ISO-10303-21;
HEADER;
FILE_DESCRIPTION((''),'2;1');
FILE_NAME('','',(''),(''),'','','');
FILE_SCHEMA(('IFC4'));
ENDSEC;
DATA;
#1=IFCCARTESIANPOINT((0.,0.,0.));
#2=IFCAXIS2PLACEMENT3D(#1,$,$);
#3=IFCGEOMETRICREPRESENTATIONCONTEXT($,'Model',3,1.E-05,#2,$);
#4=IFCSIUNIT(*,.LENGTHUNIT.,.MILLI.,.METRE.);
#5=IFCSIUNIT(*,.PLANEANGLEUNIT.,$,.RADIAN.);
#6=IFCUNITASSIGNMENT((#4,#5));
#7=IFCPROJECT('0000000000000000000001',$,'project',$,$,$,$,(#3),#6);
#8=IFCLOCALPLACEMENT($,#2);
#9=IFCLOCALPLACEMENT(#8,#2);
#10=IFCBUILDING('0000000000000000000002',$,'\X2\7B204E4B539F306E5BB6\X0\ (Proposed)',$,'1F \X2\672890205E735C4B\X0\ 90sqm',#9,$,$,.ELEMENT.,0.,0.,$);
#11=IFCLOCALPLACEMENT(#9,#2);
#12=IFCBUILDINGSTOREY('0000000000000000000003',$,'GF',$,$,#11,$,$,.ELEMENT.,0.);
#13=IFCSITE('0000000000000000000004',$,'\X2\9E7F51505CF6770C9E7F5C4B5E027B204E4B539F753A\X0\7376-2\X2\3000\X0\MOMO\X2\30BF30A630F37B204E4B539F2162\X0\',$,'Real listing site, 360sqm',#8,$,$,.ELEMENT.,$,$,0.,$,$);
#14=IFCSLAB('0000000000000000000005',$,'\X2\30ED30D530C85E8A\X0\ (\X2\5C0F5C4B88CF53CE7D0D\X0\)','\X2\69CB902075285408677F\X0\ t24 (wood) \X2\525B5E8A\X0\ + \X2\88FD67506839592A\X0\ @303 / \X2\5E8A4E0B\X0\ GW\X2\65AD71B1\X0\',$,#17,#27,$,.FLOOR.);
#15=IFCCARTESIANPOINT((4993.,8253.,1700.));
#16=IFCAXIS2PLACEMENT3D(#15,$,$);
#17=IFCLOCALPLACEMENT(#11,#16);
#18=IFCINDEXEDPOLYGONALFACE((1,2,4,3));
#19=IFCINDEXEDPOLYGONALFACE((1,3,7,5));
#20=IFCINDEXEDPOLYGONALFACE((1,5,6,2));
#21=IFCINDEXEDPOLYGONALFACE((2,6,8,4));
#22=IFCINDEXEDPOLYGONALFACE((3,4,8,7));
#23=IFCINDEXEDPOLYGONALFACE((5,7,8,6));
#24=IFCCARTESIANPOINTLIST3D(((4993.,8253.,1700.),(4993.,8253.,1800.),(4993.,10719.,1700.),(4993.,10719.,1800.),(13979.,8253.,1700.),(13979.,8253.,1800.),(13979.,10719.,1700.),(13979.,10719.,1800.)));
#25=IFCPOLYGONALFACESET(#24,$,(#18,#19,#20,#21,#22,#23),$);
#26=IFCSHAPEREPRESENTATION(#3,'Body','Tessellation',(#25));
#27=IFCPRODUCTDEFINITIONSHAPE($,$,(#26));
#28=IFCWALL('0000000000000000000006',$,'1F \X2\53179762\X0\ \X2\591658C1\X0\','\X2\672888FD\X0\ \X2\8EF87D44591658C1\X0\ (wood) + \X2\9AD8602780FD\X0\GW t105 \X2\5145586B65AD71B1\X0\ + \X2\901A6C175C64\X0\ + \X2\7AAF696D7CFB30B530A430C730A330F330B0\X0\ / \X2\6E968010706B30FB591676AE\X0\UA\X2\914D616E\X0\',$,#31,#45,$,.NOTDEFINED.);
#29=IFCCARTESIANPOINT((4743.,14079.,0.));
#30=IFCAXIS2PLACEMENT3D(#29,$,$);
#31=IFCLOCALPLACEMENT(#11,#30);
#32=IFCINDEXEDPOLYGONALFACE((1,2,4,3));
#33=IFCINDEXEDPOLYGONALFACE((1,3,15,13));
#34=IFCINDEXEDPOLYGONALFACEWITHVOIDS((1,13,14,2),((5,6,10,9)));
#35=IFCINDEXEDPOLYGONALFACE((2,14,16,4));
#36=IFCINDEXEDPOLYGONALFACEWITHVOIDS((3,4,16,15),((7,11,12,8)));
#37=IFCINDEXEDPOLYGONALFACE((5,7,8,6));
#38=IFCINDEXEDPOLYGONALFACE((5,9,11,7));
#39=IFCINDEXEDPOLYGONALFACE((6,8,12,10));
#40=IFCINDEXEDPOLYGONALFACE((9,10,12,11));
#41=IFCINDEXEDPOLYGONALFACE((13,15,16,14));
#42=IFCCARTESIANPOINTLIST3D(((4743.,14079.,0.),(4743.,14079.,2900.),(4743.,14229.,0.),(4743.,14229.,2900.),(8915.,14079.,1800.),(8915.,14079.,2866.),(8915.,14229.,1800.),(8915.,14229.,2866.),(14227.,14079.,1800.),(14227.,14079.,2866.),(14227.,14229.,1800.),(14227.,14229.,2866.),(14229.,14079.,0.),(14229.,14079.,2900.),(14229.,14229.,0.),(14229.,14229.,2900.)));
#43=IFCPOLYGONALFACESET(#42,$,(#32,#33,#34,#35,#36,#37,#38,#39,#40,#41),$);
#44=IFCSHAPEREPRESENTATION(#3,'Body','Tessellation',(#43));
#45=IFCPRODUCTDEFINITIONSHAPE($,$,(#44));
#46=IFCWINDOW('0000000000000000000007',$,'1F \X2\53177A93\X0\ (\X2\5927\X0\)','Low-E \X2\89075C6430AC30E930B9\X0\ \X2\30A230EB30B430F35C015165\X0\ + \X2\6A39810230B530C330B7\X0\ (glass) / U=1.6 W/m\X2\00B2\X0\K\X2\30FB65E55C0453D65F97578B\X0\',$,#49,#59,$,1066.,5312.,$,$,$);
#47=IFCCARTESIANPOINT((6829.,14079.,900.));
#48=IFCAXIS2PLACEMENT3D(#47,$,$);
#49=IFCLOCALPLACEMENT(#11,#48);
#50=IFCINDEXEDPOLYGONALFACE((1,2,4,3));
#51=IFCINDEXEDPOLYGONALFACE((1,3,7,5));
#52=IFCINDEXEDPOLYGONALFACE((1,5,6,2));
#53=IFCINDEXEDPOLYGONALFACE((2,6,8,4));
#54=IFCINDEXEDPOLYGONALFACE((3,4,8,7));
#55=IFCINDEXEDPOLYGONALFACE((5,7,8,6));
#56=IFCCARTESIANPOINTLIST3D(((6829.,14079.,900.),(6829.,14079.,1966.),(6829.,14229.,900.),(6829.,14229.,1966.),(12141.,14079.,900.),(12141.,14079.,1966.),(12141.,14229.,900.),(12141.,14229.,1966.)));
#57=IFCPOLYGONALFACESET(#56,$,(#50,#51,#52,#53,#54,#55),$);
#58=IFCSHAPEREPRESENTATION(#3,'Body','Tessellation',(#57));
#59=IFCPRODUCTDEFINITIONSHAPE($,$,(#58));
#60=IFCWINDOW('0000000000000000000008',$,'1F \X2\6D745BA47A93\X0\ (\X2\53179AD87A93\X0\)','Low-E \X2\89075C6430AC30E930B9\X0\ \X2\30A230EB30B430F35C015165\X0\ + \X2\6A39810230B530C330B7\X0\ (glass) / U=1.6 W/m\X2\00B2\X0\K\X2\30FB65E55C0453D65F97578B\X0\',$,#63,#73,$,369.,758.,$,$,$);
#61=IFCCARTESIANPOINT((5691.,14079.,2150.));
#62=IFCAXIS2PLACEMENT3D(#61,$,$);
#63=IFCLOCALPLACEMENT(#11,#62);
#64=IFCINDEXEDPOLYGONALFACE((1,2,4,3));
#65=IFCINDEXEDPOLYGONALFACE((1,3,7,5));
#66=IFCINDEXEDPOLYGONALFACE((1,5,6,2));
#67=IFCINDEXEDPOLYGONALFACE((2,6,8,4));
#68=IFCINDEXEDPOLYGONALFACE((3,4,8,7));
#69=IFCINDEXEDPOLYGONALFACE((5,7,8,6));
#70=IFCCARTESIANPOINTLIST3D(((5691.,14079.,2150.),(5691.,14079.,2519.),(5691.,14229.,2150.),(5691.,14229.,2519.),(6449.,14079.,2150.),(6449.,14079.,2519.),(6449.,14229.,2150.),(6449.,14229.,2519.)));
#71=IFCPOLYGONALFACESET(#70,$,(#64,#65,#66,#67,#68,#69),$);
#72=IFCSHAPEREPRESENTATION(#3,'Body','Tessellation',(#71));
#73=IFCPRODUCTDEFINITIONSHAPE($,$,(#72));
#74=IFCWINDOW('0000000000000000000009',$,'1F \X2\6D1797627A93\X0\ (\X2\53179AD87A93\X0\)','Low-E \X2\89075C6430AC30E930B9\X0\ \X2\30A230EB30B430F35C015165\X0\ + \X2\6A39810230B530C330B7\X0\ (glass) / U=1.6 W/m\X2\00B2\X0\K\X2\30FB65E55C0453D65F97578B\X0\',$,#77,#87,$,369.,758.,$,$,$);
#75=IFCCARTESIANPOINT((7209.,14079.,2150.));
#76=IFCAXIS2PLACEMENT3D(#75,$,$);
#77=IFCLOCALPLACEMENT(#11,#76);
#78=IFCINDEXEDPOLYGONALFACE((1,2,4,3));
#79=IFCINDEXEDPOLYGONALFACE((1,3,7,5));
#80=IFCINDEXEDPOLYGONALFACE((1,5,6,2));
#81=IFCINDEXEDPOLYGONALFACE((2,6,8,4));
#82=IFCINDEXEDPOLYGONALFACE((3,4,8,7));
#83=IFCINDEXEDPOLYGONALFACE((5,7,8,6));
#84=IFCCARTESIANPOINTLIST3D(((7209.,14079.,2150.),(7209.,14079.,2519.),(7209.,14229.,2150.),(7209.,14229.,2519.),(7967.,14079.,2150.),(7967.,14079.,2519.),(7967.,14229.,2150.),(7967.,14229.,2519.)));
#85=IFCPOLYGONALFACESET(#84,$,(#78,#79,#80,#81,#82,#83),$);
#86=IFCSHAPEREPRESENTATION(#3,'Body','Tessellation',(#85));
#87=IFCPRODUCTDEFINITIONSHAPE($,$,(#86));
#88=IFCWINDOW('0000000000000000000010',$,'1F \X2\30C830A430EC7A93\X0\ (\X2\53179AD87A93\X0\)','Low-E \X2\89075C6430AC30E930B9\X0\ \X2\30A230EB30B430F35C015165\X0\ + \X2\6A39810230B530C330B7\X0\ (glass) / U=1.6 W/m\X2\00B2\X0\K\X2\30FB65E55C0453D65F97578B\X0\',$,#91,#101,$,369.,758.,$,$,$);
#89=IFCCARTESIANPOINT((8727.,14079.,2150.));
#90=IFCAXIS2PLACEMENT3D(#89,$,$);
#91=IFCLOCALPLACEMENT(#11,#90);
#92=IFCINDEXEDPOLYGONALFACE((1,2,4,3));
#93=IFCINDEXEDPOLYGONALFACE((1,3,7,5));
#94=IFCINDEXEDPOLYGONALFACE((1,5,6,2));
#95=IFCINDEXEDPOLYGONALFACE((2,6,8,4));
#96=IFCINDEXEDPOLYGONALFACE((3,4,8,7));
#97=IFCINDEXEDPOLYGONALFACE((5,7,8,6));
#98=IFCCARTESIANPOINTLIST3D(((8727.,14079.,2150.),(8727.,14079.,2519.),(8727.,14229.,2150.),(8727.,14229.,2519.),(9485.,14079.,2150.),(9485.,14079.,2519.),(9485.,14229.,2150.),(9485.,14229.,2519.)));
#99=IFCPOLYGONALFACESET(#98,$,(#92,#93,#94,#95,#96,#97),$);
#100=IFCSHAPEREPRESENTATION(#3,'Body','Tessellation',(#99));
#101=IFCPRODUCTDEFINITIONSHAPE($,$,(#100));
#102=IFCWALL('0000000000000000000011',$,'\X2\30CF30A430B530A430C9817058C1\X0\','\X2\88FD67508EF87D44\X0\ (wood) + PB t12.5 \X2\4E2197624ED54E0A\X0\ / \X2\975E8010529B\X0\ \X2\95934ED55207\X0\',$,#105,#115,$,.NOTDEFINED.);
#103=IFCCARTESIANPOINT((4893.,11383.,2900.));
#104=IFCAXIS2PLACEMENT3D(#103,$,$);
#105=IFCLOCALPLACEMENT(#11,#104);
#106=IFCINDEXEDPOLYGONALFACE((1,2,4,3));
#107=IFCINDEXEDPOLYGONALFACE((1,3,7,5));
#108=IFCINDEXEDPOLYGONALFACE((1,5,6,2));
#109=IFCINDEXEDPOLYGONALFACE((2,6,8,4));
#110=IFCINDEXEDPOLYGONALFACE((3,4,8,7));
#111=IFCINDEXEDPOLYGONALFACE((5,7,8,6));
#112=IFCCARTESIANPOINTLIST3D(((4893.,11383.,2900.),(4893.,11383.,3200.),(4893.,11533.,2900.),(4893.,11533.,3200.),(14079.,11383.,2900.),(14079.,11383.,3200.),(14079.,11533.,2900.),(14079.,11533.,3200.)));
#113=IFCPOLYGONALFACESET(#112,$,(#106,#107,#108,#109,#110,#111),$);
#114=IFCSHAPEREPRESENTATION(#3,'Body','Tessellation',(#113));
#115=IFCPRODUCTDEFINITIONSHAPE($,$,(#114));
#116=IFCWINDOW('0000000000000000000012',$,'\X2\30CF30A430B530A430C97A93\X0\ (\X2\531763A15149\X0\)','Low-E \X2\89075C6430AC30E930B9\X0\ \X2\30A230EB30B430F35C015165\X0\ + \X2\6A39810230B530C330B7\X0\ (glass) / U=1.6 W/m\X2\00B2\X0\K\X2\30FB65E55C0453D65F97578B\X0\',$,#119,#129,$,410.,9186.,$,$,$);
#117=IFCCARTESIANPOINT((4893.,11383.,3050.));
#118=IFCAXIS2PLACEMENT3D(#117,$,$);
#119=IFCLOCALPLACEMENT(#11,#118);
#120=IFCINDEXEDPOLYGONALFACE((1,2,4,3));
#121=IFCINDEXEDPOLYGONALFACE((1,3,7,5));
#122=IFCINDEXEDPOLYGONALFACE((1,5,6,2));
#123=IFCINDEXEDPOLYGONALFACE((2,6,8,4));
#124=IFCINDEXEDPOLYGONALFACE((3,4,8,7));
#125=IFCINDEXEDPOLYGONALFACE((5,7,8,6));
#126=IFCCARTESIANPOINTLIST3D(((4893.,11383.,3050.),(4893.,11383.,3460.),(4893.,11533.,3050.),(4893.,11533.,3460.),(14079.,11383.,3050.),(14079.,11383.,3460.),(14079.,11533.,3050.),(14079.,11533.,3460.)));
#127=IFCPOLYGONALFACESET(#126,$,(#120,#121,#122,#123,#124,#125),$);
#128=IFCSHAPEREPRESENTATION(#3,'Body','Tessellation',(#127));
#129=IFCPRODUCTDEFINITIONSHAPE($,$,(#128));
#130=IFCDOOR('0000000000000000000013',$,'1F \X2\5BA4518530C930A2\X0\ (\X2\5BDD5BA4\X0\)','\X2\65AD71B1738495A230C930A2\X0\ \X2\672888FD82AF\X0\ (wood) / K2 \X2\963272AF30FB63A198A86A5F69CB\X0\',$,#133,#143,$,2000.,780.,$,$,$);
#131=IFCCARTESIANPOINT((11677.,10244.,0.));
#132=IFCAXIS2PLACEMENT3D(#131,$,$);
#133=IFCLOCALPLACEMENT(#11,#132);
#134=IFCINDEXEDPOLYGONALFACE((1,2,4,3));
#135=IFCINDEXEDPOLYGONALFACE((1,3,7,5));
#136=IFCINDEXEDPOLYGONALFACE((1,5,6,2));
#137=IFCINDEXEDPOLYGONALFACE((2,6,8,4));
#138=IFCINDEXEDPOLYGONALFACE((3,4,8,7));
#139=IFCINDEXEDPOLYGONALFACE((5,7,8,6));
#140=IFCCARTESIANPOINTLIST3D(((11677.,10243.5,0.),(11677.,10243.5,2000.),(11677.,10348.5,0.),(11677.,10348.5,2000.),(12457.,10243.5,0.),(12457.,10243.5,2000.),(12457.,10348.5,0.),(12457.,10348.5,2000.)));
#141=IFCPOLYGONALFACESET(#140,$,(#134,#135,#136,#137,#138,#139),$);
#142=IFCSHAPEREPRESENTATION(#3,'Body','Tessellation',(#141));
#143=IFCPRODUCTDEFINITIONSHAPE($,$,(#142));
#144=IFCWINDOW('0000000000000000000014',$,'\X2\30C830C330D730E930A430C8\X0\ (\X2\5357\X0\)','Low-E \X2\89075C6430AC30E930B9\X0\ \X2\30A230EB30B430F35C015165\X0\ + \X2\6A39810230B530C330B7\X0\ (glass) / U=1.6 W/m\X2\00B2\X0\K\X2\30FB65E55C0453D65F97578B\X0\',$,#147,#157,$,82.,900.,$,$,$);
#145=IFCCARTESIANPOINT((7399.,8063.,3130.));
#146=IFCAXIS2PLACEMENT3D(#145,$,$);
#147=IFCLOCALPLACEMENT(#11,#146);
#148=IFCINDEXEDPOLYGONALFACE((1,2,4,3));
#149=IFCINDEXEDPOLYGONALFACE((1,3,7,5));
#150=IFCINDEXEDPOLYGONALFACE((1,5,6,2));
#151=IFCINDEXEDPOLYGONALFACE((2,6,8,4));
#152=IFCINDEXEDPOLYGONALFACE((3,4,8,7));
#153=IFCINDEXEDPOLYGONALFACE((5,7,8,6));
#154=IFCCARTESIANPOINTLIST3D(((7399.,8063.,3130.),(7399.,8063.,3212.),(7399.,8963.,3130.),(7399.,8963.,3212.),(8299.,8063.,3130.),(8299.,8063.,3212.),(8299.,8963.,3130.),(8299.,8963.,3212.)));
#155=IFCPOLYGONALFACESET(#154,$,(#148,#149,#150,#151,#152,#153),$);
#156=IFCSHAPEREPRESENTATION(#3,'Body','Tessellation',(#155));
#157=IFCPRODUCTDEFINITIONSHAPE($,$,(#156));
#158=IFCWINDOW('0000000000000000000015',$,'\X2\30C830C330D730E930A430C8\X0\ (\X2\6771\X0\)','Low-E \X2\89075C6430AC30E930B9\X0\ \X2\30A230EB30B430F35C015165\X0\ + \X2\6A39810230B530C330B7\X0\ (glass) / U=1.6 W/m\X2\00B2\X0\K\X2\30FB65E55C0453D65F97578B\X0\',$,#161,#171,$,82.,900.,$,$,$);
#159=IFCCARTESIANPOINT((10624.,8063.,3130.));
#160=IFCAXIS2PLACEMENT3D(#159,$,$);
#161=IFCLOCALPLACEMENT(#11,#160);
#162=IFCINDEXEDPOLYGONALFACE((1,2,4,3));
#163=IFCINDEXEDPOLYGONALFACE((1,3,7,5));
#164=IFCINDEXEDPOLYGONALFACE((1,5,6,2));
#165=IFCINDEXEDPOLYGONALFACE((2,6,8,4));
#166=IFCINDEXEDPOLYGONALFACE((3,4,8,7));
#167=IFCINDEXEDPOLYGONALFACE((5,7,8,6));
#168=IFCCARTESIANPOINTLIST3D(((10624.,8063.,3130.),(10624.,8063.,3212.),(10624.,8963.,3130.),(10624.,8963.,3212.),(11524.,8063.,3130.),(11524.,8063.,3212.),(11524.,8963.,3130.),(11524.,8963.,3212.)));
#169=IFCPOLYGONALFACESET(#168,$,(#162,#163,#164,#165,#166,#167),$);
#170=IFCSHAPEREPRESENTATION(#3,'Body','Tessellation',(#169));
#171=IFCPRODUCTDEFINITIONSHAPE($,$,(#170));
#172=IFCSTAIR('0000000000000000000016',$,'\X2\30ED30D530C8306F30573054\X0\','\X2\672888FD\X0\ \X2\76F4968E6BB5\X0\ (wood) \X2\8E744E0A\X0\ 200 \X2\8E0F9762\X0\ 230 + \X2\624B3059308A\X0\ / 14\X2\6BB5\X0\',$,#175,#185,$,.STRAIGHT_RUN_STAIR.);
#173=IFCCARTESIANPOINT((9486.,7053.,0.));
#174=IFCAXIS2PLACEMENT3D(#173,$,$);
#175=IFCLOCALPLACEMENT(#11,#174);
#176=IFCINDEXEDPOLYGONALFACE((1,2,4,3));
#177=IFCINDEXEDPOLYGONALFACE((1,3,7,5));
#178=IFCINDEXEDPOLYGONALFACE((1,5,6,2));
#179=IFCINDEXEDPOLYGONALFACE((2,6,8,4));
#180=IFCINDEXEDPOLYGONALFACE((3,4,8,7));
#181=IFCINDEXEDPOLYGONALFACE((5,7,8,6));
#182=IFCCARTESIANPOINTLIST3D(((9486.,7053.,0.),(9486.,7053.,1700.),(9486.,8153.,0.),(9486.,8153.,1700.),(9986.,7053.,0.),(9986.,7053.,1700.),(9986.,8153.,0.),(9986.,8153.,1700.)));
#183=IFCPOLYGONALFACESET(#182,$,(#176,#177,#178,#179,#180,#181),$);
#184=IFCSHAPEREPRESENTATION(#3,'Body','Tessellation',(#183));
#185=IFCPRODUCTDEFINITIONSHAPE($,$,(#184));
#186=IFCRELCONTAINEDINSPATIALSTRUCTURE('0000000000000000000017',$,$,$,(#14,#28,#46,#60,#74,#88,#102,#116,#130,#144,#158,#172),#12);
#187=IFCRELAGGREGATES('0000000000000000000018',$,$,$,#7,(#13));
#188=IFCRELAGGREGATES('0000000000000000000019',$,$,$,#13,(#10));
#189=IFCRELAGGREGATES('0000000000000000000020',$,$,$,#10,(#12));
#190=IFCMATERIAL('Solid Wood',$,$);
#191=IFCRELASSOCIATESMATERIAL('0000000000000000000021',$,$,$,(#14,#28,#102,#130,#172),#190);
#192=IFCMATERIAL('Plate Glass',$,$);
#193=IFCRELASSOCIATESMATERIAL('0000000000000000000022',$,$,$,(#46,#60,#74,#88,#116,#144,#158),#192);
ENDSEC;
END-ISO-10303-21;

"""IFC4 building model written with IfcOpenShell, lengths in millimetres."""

from ifc_helpers import new_model, si_unit, frame, frame_2d, origin, place, context, project, spatial, rectangle, extrude, material, element, fill, save


model = new_model("IFC4")

# Units and contexts
model_context = context("Model", 3, precision=1e-05, world=origin())
ifc_project = project(units=[si_unit("LENGTHUNIT", "METRE", prefix="MILLI"), si_unit("PLANEANGLEUNIT", "RADIAN")], contexts=[model_context])

# Site, building, storey
site_placement = place(None, origin())
site = spatial("IfcSite", under=ifc_project, at=site_placement, Name="鹿児島県鹿屋市笠之原町7376-2　MOMOタウン笠之原Ⅲ", ObjectType="Real listing site, 360sqm", CompositionType="ELEMENT", RefElevation=0.0)
building_placement = place(site_placement, origin())
building = spatial("IfcBuilding", under=site, at=building_placement, Name="笠之原の家 (Proposed)", ObjectType="1F 木造平屋 90sqm", CompositionType="ELEMENT", ElevationOfRefHeight=0.0, ElevationOfTerrain=0.0)
storey_placement = place(building_placement, origin())
storey = spatial("IfcBuildingStorey", under=building, at=storey_placement, Name="GF", CompositionType="ELEMENT", Elevation=0.0)

# Slab
ifc_material_1 = material(Name="Solid Wood")
slab_placement = place(storey_placement, frame((4993.0, 8253.0, 1700.0)))
element("IfcSlab", 1, at=slab_placement, inside=storey, material=ifc_material_1, Name="ロフト床 (小屋裏収納)", Description="構造用合板 t24 (wood) 剛床 + 製材根太 @303 / 床下 GW断熱", PredefinedType="FLOOR", context=model_context, shape_type="SweptSolid", body=[
    extrude(rectangle(XDim=8986.0, YDim=2466.0, at=frame_2d((4493.0, 1233.0))), frame((4993.0, 8253.0, 1700.0)), (0.0, 0.0, 1.0), 100.0),
])

# Wall, openings, windows
wall_1_placement = place(storey_placement, frame((4743.0, 14079.0, 0.0)))
wall_1 = element("IfcWall", 2, at=wall_1_placement, inside=storey, material=ifc_material_1, Name="1F 北面 外壁", Description="木製 軸組外壁 (wood) + 高性能GW t105 充填断熱 + 通気層 + 窯業系サイディング / 準耐火・外皮UA配慮", PredefinedType="NOTDEFINED", context=model_context, shape_type="SweptSolid", body=[
    extrude(rectangle(XDim=9486.0, YDim=150.0, at=frame_2d((4743.0, 75.0))), frame((4743.0, 14079.0, 0.0)), (0.0, 0.0, 1.0), 2900.0),
])
opening_1_placement = place(storey_placement, frame((6829.0, 14079.0, 900.0)))
opening_1 = element("IfcOpeningElement", 3, at=opening_1_placement, cuts=wall_1, PredefinedType="NOTDEFINED", context=model_context, shape_type="SweptSolid", body=[
    extrude(rectangle(XDim=5312.0, YDim=150.0, at=frame_2d((2656.0, 75.0))), frame((6829.0, 14079.0, 900.0)), (0.0, 0.0, 1.0), 1066.0),
])
opening_2_placement = place(storey_placement, frame((5691.0, 14079.0, 2150.0)))
opening_2 = element("IfcOpeningElement", 4, at=opening_2_placement, cuts=wall_1, PredefinedType="NOTDEFINED", context=model_context, shape_type="SweptSolid", body=[
    extrude(rectangle(XDim=758.0, YDim=150.0, at=frame_2d((379.0, 75.0))), frame((5691.0, 14079.0, 2150.0)), (0.0, 0.0, 1.0), 369.0),
])
opening_3_placement = place(storey_placement, frame((7209.0, 14079.0, 2150.0)))
opening_3 = element("IfcOpeningElement", 5, at=opening_3_placement, cuts=wall_1, PredefinedType="NOTDEFINED", context=model_context, shape_type="SweptSolid", body=[
    extrude(rectangle(XDim=758.0, YDim=150.0, at=frame_2d((379.0, 75.0))), frame((7209.0, 14079.0, 2150.0)), (0.0, 0.0, 1.0), 369.0),
])
opening_4_placement = place(storey_placement, frame((8727.0, 14079.0, 2150.0)))
opening_4 = element("IfcOpeningElement", 6, at=opening_4_placement, cuts=wall_1, PredefinedType="NOTDEFINED", context=model_context, shape_type="SweptSolid", body=[
    extrude(rectangle(XDim=758.0, YDim=150.0, at=frame_2d((379.0, 75.0))), frame((8727.0, 14079.0, 2150.0)), (0.0, 0.0, 1.0), 369.0),
])
ifc_material_2 = material(Name="Plate Glass")
window_1_placement = place(storey_placement, frame((6829.0, 14079.0, 900.0)))
window_1 = element("IfcWindow", 7, at=window_1_placement, inside=storey, material=ifc_material_2, Name="1F 北窓 (大)", Description="Low-E 複層ガラス アルゴン封入 + 樹脂サッシ (glass) / U=1.6 W/m²K・日射取得型", OverallHeight=1066.0, OverallWidth=5312.0, context=model_context, shape_type="SweptSolid", body=[
    extrude(rectangle(XDim=5312.0, YDim=150.0, at=frame_2d((2656.0, 75.0))), frame((6829.0, 14079.0, 900.0)), (0.0, 0.0, 1.0), 1066.0),
])
fill(opening_1, window_1)
window_2_placement = place(storey_placement, frame((5691.0, 14079.0, 2150.0)))
window_2 = element("IfcWindow", 8, at=window_2_placement, inside=storey, material=ifc_material_2, Name="1F 浴室窓 (北高窓)", Description="Low-E 複層ガラス アルゴン封入 + 樹脂サッシ (glass) / U=1.6 W/m²K・日射取得型", OverallHeight=369.0, OverallWidth=758.0, context=model_context, shape_type="SweptSolid", body=[
    extrude(rectangle(XDim=758.0, YDim=150.0, at=frame_2d((379.0, 75.0))), frame((5691.0, 14079.0, 2150.0)), (0.0, 0.0, 1.0), 369.0),
])
fill(opening_2, window_2)
window_3_placement = place(storey_placement, frame((7209.0, 14079.0, 2150.0)))
window_3 = element("IfcWindow", 9, at=window_3_placement, inside=storey, material=ifc_material_2, Name="1F 洗面窓 (北高窓)", Description="Low-E 複層ガラス アルゴン封入 + 樹脂サッシ (glass) / U=1.6 W/m²K・日射取得型", OverallHeight=369.0, OverallWidth=758.0, context=model_context, shape_type="SweptSolid", body=[
    extrude(rectangle(XDim=758.0, YDim=150.0, at=frame_2d((379.0, 75.0))), frame((7209.0, 14079.0, 2150.0)), (0.0, 0.0, 1.0), 369.0),
])
fill(opening_3, window_3)
window_4_placement = place(storey_placement, frame((8727.0, 14079.0, 2150.0)))
window_4 = element("IfcWindow", 10, at=window_4_placement, inside=storey, material=ifc_material_2, Name="1F トイレ窓 (北高窓)", Description="Low-E 複層ガラス アルゴン封入 + 樹脂サッシ (glass) / U=1.6 W/m²K・日射取得型", OverallHeight=369.0, OverallWidth=758.0, context=model_context, shape_type="SweptSolid", body=[
    extrude(rectangle(XDim=758.0, YDim=150.0, at=frame_2d((379.0, 75.0))), frame((8727.0, 14079.0, 2150.0)), (0.0, 0.0, 1.0), 369.0),
])
fill(opening_4, window_4)

# Wall, opening, window
wall_2_placement = place(storey_placement, frame((4893.0, 11383.0, 2900.0)))
wall_2 = element("IfcWall", 11, at=wall_2_placement, inside=storey, material=ifc_material_1, Name="ハイサイド腰壁", Description="製材軸組 (wood) + PB t12.5 両面仕上 / 非耐力 間仕切", PredefinedType="NOTDEFINED", context=model_context, shape_type="SweptSolid", body=[
    extrude(rectangle(XDim=9186.0, YDim=150.0, at=frame_2d((4593.0, 75.0))), frame((4893.0, 11383.0, 2900.0)), (0.0, 0.0, 1.0), 700.0),
])
opening_5_placement = place(storey_placement, frame((4893.0, 11383.0, 3050.0)))
opening_5 = element("IfcOpeningElement", 12, at=opening_5_placement, cuts=wall_2, PredefinedType="NOTDEFINED", context=model_context, shape_type="SweptSolid", body=[
    extrude(rectangle(XDim=9186.0, YDim=150.0, at=frame_2d((4593.0, 75.0))), frame((4893.0, 11383.0, 3050.0)), (0.0, 0.0, 1.0), 410.0),
])
window_5_placement = place(storey_placement, frame((4893.0, 11383.0, 3050.0)))
window_5 = element("IfcWindow", 13, at=window_5_placement, inside=storey, material=ifc_material_2, Name="ハイサイド窓 (北採光)", Description="Low-E 複層ガラス アルゴン封入 + 樹脂サッシ (glass) / U=1.6 W/m²K・日射取得型", OverallHeight=410.0, OverallWidth=9186.0, context=model_context, shape_type="SweptSolid", body=[
    extrude(rectangle(XDim=9186.0, YDim=150.0, at=frame_2d((4593.0, 75.0))), frame((4893.0, 11383.0, 3050.0)), (0.0, 0.0, 1.0), 410.0),
])
fill(opening_5, window_5)

# Door
door_1_placement = place(storey_placement, frame((11677.0, 10244.0, 0.0)))
element("IfcDoor", 14, at=door_1_placement, inside=storey, material=ifc_material_1, Name="1F 室内ドア (寝室)", Description="断熱玄関ドア 木製芯 (wood) / K2 防犯・採風機構", OverallHeight=2000.0, OverallWidth=780.0, context=model_context, shape_type="SweptSolid", body=[
    extrude(rectangle(XDim=780.0, YDim=105.0, at=frame_2d((390.0, 52.0))), frame((11677.0, 10244.0, 0.0)), (0.0, 0.0, 1.0), 2000.0),
])

# Windows
window_6_placement = place(storey_placement, frame((7399.0, 8063.0, 3130.0)))
element("IfcWindow", 15, at=window_6_placement, inside=storey, material=ifc_material_2, Name="トップライト (南)", Description="Low-E 複層ガラス アルゴン封入 + 樹脂サッシ (glass) / U=1.6 W/m²K・日射取得型", OverallHeight=82.0, OverallWidth=900.0, context=model_context, shape_type="SweptSolid", body=[
    extrude(rectangle(XDim=900.0, YDim=900.0, at=frame_2d((450.0, 450.0))), frame((7399.0, 8063.0, 3130.0)), (0.0, 0.0, 1.0), 82.0),
])
window_7_placement = place(storey_placement, frame((10624.0, 8063.0, 3130.0)))
element("IfcWindow", 16, at=window_7_placement, inside=storey, material=ifc_material_2, Name="トップライト (東)", Description="Low-E 複層ガラス アルゴン封入 + 樹脂サッシ (glass) / U=1.6 W/m²K・日射取得型", OverallHeight=82.0, OverallWidth=900.0, context=model_context, shape_type="SweptSolid", body=[
    extrude(rectangle(XDim=900.0, YDim=900.0, at=frame_2d((450.0, 450.0))), frame((10624.0, 8063.0, 3130.0)), (0.0, 0.0, 1.0), 82.0),
])

# Stair
stair_placement = place(storey_placement, frame((9486.0, 7053.0, 0.0)))
element("IfcStair", 17, at=stair_placement, inside=storey, material=ifc_material_1, Name="ロフトはしご", Description="木製 直階段 (wood) 蹴上 200 踏面 230 + 手すり / 14段", PredefinedType="STRAIGHT_RUN_STAIR", context=model_context, shape_type="SweptSolid", body=[
    extrude(rectangle(XDim=500.0, YDim=1100.0, at=frame_2d((250.0, 550.0))), frame((9486.0, 7053.0, 0.0)), (0.0, 0.0, 1.0), 1700.0),
])

save(model, "model.ifc")
